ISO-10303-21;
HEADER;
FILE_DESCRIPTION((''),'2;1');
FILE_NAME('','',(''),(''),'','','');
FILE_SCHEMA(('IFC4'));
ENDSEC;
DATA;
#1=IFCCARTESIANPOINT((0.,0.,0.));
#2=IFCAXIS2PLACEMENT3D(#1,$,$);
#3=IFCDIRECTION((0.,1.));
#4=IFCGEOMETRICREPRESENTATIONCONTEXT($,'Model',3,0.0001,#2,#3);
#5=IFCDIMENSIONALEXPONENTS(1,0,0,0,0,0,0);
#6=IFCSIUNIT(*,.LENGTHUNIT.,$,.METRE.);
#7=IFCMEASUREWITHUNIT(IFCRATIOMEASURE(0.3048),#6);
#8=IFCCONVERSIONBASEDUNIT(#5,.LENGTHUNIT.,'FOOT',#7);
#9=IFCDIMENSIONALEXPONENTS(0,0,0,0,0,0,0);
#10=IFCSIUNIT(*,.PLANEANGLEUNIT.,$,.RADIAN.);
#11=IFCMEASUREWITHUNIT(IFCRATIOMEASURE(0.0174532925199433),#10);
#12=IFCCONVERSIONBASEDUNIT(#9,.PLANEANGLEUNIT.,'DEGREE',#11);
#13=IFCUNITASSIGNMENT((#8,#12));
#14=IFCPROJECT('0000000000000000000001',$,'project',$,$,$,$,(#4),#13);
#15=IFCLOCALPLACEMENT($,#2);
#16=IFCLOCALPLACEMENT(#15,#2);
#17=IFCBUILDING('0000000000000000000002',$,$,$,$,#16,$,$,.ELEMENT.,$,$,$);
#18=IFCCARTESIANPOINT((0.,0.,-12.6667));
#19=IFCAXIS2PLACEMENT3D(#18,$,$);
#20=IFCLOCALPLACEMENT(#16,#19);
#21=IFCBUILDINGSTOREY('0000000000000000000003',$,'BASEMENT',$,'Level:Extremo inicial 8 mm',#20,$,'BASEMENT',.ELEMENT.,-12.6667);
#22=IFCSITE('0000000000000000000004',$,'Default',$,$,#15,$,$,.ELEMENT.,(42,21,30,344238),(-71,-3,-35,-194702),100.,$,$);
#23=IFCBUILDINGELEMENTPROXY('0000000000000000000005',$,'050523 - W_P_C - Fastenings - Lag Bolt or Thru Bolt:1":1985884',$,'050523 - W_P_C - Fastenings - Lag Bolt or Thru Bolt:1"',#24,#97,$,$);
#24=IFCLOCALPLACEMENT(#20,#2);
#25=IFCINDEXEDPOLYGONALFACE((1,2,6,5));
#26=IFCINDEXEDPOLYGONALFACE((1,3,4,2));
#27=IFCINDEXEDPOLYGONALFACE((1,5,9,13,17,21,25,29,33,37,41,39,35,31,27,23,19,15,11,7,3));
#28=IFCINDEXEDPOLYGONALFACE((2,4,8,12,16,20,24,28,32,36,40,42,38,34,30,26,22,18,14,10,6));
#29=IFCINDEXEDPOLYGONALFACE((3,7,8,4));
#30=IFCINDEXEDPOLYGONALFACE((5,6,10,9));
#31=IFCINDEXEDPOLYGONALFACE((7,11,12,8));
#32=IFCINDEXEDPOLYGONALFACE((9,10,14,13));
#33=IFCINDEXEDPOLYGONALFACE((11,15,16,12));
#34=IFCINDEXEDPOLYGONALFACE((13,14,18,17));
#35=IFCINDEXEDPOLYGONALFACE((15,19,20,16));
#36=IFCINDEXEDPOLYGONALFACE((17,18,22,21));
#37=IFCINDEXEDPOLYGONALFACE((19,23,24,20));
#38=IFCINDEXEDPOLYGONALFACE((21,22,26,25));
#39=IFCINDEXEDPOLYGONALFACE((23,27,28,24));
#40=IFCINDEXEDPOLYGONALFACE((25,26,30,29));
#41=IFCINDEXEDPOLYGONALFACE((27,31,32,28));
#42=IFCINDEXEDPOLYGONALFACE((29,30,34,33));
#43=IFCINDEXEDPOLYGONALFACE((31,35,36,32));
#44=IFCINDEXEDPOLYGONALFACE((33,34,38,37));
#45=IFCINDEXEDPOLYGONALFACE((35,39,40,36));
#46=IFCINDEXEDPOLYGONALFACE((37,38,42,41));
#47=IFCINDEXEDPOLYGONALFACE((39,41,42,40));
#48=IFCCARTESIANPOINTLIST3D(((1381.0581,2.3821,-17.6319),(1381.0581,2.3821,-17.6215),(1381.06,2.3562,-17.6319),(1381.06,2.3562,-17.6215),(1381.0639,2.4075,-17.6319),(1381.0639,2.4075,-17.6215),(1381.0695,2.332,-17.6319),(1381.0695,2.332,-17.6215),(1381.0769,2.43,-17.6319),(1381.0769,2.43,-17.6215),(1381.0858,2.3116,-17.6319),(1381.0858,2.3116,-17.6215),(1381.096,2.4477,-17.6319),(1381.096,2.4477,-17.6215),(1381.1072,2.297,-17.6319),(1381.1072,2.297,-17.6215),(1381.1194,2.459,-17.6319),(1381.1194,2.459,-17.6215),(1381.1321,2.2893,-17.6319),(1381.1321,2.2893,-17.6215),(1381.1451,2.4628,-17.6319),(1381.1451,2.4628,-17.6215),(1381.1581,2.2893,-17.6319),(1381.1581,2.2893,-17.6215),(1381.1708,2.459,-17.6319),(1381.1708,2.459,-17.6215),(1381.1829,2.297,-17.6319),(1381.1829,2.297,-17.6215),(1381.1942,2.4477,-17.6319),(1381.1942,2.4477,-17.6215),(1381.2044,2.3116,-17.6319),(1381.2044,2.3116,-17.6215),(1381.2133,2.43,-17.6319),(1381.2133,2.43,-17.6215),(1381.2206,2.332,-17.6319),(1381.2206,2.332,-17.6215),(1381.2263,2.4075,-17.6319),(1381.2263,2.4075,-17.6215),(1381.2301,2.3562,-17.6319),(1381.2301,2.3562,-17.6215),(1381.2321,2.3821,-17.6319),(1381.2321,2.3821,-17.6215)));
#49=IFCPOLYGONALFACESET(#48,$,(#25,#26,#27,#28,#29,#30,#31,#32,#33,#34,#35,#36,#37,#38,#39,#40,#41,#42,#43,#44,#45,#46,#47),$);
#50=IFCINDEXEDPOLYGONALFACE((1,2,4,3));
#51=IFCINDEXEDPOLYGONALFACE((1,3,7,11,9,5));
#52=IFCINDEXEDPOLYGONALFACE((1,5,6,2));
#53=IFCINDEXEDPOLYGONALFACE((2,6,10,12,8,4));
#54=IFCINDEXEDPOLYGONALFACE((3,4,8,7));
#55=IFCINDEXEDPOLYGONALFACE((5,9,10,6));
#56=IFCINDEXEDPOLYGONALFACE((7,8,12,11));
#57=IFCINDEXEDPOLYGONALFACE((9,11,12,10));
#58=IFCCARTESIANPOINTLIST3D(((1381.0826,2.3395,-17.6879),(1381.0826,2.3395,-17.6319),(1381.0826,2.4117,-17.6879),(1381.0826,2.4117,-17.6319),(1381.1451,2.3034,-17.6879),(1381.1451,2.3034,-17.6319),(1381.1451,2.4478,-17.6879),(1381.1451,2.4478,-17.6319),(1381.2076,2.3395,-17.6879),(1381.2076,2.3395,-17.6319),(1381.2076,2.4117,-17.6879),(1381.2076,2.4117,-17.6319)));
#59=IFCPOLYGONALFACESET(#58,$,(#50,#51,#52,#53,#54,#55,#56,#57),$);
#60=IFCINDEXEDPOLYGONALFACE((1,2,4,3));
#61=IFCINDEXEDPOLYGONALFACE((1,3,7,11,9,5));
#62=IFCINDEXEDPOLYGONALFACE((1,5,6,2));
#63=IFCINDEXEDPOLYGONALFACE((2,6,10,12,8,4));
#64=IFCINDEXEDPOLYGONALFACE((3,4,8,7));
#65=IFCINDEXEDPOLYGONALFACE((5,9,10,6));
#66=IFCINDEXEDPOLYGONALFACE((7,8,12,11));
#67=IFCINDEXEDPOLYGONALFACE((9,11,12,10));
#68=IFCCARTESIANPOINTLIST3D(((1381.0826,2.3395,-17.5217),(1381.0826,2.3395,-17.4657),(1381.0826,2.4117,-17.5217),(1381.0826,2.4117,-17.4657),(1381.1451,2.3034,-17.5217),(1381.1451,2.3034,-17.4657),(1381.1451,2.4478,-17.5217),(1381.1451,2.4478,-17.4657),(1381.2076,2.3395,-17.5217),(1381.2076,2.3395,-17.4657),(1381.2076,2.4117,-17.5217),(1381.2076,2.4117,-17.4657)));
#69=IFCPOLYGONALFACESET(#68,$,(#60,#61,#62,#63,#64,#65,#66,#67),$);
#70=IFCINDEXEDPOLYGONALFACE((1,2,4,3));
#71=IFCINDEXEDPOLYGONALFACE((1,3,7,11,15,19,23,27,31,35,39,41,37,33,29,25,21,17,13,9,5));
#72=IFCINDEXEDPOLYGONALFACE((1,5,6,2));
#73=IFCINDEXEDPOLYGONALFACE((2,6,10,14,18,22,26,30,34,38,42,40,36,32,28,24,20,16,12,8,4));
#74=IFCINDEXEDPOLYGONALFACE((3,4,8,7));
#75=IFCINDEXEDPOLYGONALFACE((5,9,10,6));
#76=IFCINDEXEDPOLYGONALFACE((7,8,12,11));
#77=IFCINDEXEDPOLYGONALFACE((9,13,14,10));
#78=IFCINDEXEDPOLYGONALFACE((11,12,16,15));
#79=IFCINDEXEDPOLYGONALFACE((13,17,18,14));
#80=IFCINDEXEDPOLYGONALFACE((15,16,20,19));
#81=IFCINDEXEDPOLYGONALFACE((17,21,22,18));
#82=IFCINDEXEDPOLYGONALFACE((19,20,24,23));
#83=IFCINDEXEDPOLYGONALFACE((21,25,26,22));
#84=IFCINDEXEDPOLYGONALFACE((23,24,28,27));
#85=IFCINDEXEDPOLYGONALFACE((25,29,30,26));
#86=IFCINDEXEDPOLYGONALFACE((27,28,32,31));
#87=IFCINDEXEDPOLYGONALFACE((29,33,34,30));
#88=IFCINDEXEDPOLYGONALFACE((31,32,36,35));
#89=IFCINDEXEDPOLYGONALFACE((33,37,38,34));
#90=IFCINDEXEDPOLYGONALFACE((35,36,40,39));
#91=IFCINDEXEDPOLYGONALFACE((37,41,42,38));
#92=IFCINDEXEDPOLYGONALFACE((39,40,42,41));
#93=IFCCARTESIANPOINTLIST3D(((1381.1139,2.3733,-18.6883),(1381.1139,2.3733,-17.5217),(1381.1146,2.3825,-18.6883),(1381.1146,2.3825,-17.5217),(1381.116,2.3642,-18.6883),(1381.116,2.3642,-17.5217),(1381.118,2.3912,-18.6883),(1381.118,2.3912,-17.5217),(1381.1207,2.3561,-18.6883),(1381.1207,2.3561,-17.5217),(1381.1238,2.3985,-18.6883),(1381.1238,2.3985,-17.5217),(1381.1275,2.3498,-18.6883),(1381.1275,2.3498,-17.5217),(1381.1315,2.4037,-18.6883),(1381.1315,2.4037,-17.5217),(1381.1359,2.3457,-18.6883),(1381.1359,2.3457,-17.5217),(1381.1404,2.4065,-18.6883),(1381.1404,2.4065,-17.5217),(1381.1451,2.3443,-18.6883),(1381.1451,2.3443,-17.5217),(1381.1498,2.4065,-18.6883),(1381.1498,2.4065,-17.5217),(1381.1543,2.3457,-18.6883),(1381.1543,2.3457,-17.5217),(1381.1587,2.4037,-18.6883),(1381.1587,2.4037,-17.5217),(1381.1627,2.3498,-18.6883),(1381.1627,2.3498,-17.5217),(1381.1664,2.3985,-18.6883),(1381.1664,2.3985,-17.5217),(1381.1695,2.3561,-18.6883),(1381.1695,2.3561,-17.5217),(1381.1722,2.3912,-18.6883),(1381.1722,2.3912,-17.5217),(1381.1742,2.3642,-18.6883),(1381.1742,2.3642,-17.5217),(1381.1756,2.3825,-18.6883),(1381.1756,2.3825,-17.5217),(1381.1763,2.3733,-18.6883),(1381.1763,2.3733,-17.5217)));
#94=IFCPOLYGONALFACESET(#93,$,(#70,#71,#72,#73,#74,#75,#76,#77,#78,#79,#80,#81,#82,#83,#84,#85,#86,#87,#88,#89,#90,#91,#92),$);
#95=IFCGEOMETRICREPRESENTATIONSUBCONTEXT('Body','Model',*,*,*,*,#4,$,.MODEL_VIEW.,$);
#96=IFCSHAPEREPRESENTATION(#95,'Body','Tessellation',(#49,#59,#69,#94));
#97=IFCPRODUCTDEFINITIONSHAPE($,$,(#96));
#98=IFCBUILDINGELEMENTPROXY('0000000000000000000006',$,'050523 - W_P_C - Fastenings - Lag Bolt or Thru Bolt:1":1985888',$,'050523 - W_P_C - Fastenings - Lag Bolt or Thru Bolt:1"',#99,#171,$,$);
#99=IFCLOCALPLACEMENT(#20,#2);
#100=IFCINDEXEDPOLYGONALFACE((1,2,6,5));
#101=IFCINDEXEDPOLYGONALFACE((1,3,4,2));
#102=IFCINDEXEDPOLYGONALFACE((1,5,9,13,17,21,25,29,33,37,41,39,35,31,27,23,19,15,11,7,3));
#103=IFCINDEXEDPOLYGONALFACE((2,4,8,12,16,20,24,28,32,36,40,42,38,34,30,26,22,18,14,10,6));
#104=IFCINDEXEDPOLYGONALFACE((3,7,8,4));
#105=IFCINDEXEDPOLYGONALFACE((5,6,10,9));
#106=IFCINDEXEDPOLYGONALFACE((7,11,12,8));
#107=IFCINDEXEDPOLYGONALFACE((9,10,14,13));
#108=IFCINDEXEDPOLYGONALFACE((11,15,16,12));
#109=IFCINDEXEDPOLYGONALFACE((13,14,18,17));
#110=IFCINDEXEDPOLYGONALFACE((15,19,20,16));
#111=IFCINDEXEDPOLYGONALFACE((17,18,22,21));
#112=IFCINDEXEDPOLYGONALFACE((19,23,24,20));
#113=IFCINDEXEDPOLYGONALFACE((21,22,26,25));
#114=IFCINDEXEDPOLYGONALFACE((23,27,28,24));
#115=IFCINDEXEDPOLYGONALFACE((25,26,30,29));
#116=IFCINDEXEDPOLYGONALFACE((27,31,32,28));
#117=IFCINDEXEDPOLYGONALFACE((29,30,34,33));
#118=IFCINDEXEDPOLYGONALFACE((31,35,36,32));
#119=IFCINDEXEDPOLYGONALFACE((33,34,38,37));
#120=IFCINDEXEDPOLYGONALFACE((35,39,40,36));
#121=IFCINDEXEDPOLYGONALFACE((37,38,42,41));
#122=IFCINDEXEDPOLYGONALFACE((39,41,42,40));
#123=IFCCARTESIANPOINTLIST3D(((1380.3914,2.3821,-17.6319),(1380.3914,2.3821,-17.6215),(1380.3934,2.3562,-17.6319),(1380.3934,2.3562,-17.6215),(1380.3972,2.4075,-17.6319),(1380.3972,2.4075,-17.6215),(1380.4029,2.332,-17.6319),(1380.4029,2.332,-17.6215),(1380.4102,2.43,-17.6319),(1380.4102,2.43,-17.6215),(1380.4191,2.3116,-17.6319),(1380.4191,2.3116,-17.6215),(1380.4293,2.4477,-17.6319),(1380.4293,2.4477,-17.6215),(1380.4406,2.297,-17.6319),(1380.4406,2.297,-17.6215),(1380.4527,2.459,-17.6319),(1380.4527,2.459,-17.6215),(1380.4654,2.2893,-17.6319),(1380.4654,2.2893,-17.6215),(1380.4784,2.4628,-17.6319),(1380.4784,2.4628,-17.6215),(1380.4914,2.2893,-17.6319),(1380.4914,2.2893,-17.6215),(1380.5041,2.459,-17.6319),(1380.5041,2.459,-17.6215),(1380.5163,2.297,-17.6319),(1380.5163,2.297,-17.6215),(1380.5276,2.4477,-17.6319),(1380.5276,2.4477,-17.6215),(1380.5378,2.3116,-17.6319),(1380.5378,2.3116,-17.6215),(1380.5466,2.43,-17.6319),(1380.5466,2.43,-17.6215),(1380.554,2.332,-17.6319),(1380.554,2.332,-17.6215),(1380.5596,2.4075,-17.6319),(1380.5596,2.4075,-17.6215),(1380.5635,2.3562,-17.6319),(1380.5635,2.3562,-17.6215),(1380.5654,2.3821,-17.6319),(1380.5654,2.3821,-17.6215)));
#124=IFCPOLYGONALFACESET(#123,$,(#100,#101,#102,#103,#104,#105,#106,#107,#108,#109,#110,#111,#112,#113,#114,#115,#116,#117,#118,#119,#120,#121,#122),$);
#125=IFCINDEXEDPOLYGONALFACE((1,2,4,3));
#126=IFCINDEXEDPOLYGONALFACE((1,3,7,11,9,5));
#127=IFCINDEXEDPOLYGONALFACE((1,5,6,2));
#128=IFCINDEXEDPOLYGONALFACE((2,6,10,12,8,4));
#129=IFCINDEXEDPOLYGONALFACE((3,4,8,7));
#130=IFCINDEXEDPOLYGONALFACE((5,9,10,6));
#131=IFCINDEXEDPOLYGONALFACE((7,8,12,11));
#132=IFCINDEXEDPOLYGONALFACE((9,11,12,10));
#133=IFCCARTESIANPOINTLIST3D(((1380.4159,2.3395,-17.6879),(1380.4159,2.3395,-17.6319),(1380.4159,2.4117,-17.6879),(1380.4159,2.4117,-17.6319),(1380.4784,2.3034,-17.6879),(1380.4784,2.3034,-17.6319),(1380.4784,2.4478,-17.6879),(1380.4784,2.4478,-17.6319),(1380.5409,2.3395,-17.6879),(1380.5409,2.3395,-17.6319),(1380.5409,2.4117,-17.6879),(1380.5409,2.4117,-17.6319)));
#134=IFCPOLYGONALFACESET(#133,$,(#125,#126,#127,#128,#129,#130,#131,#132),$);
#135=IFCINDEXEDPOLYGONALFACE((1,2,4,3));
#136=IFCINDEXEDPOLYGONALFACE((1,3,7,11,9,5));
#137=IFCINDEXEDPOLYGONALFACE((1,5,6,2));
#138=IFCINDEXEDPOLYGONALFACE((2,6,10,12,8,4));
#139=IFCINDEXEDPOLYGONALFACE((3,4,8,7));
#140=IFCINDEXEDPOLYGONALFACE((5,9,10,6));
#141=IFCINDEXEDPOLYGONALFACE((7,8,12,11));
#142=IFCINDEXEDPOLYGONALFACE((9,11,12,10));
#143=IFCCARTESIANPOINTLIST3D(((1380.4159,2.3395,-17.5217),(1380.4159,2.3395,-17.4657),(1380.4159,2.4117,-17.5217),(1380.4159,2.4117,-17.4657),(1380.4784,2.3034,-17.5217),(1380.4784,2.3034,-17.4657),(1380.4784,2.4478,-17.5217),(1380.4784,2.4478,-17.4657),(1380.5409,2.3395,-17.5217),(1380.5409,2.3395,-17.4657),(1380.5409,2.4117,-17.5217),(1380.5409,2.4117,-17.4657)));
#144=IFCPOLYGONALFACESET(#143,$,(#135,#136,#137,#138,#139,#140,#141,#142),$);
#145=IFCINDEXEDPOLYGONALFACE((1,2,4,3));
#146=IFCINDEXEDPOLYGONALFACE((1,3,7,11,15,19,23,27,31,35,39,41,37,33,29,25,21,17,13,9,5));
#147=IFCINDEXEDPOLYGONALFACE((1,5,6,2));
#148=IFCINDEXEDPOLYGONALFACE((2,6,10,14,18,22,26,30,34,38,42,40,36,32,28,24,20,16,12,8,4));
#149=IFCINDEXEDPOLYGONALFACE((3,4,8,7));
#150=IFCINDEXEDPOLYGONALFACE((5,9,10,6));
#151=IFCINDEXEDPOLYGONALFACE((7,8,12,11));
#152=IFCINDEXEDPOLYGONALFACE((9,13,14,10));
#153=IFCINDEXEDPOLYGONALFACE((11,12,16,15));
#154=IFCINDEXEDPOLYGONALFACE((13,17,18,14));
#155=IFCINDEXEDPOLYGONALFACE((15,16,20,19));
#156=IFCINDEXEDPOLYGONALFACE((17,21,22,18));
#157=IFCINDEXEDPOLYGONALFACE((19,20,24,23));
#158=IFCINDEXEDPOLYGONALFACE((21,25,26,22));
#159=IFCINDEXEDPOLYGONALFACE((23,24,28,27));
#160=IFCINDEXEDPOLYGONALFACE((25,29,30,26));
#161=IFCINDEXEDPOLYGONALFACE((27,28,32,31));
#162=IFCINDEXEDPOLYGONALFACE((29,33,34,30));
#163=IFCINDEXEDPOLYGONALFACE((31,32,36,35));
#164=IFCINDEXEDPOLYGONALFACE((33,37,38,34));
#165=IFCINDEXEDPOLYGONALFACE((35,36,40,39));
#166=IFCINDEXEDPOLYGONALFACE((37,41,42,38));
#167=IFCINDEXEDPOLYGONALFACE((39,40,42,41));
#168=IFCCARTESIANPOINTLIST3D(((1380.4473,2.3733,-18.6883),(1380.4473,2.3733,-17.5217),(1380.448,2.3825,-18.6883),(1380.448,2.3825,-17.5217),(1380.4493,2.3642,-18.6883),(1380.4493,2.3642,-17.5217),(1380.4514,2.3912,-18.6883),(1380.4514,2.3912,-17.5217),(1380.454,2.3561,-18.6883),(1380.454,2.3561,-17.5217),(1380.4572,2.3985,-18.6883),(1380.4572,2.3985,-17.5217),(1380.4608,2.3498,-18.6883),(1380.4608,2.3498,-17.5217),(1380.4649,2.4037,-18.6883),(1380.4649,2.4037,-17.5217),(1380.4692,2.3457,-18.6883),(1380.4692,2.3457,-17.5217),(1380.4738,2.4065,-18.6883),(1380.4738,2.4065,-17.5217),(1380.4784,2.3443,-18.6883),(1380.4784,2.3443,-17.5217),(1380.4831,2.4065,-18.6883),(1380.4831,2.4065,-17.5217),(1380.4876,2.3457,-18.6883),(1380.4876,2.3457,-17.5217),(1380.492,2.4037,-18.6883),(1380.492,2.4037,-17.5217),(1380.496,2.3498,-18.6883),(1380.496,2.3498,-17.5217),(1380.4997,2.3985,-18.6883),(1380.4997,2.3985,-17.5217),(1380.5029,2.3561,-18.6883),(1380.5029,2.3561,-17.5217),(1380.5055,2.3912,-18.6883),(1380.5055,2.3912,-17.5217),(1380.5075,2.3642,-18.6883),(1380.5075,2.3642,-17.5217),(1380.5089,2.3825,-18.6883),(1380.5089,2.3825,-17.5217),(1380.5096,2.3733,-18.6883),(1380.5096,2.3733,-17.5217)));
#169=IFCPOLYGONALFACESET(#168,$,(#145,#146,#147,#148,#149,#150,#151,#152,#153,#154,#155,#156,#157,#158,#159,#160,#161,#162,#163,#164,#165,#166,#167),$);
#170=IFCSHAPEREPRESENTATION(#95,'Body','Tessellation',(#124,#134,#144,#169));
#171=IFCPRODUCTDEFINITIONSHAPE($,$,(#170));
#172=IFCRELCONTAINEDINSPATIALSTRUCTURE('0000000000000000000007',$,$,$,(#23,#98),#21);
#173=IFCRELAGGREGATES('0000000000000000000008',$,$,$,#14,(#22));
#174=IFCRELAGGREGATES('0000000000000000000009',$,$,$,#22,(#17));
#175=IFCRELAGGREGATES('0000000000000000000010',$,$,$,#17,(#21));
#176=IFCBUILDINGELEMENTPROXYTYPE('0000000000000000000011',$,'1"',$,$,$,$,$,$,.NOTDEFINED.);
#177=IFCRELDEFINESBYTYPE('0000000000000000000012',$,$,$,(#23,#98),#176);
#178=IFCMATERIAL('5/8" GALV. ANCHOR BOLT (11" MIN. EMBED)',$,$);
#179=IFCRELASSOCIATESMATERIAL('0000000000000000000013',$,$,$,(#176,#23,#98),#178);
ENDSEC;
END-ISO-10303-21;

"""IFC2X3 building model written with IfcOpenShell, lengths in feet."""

from ifc_helpers import new_model, entity, si_unit, converted_unit, direction, frame, frame_2d, origin, place, context, subcontext, project, spatial, polyline, circle, outline, extrude, source, transform, mapped, material, type_object, type_shapes, element, save


model = new_model("IFC2X3")

# Units and contexts
model_context = context("Model", 3, precision=0.0001, world=origin(), true_north=direction((0.0, 1.0)))
body_context = subcontext(model_context, "Body", "Model", "MODEL_VIEW")
ifc_project = project(units=[converted_unit("LENGTHUNIT", "FOOT", entity("IfcRatioMeasure", 0.3048), si_unit("LENGTHUNIT", "METRE"), dimensions=[1, 0, 0, 0, 0, 0, 0]), converted_unit("PLANEANGLEUNIT", "DEGREE", entity("IfcRatioMeasure", 0.0174532925199433), si_unit("PLANEANGLEUNIT", "RADIAN"), dimensions=[0, 0, 0, 0, 0, 0, 0])], contexts=[model_context])

# Site, building, storey
site_placement = place(None, origin())
site = spatial("IfcSite", under=ifc_project, at=site_placement, Name="Default", CompositionType="ELEMENT", RefLatitude=(42, 21, 30, 344238), RefLongitude=(-71, -3, -35, -194702), RefElevation=100.0)
building_placement = place(site_placement, origin())
building = spatial("IfcBuilding", under=site, at=building_placement, CompositionType="ELEMENT")
storey_placement = place(building_placement, frame((0.0, 0.0, -12.6667)))
storey = spatial("IfcBuildingStorey", under=building, at=storey_placement, Name="BASEMENT", ObjectType="Level:Extremo inicial 8 mm", LongName="BASEMENT", CompositionType="ELEMENT", Elevation=-12.6667)

# Building element proxies
ifc_material_1 = material(Name="5/8\" GALV. ANCHOR BOLT (11\" MIN. EMBED)")
building_element_proxy_type_1 = type_object("IfcBuildingElementProxyType", Name="1\"", PredefinedType="NOTDEFINED", material=ifc_material_1)
shared_shape_1 = source(origin(), body_context, "Body", "SweptSolid", [
    extrude(circle(Radius=0.0872, at=frame_2d((0.0, 0.0), x_axis=(1.0, 0.0))), frame((0.0, 0.0, -0.1102), z_axis=(0.0, 0.0, 1.0), x_axis=(0.0, 1.0, 0.0)), (0.0, 0.0, 1.0), 0.0104),
    extrude(outline(polyline([(-0.0361, -0.0625), (0.0361, -0.0625), (0.0722, 0.0), (0.0361, 0.0625), (-0.0361, 0.0625), (-0.0722, 0.0), (-0.0361, -0.0625)])), frame((0.0, 0.0, -0.1662), z_axis=(0.0, 0.0, 1.0), x_axis=(0.0, -1.0, 0.0)), (0.0, 0.0, 1.0), 0.056),
    extrude(outline(polyline([(-0.0361, -0.0625), (0.0361, -0.0625), (0.0722, 0.0), (0.0361, 0.0625), (-0.0361, 0.0625), (-0.0722, 0.0), (-0.0361, -0.0625)])), frame((0.0, 0.0, 0.0), z_axis=(0.0, 0.0, 1.0), x_axis=(0.866025, -0.5, 0.0)), (0.0, 0.0, 1.0), 0.056),
    extrude(circle(Radius=0.0312, at=frame_2d((0.0, 0.0), x_axis=(1.0, 0.0))), frame((0.0, 0.0, -1.1667), z_axis=(0.0, 0.0, 1.0), x_axis=(0.0, -1.0, 0.0)), (0.0, 0.0, 1.0), 1.1667),
])
type_shapes(building_element_proxy_type_1, [shared_shape_1])
for number, where, name in (
    (1, (1381.1451, 2.3756, -17.5217), "050523 - W_P_C - Fastenings - Lag Bolt or Thru Bolt:1\":1985884"),
    (2, (1380.4784, 2.3756, -17.5217), "050523 - W_P_C - Fastenings - Lag Bolt or Thru Bolt:1\":1985888"),
):
    element("IfcBuildingElementProxy", number, at=place(storey_placement, frame(where)), inside=storey, type_object=building_element_proxy_type_1, material=ifc_material_1, Name=name, ObjectType="050523 - W_P_C - Fastenings - Lag Bolt or Thru Bolt:1\"", context=body_context, shape_type="MappedRepresentation", body=[
        mapped(shared_shape_1, transform((0.0, 0.0, 0.0), scale=1.0)),
    ])

save(model, "model.ifc")
